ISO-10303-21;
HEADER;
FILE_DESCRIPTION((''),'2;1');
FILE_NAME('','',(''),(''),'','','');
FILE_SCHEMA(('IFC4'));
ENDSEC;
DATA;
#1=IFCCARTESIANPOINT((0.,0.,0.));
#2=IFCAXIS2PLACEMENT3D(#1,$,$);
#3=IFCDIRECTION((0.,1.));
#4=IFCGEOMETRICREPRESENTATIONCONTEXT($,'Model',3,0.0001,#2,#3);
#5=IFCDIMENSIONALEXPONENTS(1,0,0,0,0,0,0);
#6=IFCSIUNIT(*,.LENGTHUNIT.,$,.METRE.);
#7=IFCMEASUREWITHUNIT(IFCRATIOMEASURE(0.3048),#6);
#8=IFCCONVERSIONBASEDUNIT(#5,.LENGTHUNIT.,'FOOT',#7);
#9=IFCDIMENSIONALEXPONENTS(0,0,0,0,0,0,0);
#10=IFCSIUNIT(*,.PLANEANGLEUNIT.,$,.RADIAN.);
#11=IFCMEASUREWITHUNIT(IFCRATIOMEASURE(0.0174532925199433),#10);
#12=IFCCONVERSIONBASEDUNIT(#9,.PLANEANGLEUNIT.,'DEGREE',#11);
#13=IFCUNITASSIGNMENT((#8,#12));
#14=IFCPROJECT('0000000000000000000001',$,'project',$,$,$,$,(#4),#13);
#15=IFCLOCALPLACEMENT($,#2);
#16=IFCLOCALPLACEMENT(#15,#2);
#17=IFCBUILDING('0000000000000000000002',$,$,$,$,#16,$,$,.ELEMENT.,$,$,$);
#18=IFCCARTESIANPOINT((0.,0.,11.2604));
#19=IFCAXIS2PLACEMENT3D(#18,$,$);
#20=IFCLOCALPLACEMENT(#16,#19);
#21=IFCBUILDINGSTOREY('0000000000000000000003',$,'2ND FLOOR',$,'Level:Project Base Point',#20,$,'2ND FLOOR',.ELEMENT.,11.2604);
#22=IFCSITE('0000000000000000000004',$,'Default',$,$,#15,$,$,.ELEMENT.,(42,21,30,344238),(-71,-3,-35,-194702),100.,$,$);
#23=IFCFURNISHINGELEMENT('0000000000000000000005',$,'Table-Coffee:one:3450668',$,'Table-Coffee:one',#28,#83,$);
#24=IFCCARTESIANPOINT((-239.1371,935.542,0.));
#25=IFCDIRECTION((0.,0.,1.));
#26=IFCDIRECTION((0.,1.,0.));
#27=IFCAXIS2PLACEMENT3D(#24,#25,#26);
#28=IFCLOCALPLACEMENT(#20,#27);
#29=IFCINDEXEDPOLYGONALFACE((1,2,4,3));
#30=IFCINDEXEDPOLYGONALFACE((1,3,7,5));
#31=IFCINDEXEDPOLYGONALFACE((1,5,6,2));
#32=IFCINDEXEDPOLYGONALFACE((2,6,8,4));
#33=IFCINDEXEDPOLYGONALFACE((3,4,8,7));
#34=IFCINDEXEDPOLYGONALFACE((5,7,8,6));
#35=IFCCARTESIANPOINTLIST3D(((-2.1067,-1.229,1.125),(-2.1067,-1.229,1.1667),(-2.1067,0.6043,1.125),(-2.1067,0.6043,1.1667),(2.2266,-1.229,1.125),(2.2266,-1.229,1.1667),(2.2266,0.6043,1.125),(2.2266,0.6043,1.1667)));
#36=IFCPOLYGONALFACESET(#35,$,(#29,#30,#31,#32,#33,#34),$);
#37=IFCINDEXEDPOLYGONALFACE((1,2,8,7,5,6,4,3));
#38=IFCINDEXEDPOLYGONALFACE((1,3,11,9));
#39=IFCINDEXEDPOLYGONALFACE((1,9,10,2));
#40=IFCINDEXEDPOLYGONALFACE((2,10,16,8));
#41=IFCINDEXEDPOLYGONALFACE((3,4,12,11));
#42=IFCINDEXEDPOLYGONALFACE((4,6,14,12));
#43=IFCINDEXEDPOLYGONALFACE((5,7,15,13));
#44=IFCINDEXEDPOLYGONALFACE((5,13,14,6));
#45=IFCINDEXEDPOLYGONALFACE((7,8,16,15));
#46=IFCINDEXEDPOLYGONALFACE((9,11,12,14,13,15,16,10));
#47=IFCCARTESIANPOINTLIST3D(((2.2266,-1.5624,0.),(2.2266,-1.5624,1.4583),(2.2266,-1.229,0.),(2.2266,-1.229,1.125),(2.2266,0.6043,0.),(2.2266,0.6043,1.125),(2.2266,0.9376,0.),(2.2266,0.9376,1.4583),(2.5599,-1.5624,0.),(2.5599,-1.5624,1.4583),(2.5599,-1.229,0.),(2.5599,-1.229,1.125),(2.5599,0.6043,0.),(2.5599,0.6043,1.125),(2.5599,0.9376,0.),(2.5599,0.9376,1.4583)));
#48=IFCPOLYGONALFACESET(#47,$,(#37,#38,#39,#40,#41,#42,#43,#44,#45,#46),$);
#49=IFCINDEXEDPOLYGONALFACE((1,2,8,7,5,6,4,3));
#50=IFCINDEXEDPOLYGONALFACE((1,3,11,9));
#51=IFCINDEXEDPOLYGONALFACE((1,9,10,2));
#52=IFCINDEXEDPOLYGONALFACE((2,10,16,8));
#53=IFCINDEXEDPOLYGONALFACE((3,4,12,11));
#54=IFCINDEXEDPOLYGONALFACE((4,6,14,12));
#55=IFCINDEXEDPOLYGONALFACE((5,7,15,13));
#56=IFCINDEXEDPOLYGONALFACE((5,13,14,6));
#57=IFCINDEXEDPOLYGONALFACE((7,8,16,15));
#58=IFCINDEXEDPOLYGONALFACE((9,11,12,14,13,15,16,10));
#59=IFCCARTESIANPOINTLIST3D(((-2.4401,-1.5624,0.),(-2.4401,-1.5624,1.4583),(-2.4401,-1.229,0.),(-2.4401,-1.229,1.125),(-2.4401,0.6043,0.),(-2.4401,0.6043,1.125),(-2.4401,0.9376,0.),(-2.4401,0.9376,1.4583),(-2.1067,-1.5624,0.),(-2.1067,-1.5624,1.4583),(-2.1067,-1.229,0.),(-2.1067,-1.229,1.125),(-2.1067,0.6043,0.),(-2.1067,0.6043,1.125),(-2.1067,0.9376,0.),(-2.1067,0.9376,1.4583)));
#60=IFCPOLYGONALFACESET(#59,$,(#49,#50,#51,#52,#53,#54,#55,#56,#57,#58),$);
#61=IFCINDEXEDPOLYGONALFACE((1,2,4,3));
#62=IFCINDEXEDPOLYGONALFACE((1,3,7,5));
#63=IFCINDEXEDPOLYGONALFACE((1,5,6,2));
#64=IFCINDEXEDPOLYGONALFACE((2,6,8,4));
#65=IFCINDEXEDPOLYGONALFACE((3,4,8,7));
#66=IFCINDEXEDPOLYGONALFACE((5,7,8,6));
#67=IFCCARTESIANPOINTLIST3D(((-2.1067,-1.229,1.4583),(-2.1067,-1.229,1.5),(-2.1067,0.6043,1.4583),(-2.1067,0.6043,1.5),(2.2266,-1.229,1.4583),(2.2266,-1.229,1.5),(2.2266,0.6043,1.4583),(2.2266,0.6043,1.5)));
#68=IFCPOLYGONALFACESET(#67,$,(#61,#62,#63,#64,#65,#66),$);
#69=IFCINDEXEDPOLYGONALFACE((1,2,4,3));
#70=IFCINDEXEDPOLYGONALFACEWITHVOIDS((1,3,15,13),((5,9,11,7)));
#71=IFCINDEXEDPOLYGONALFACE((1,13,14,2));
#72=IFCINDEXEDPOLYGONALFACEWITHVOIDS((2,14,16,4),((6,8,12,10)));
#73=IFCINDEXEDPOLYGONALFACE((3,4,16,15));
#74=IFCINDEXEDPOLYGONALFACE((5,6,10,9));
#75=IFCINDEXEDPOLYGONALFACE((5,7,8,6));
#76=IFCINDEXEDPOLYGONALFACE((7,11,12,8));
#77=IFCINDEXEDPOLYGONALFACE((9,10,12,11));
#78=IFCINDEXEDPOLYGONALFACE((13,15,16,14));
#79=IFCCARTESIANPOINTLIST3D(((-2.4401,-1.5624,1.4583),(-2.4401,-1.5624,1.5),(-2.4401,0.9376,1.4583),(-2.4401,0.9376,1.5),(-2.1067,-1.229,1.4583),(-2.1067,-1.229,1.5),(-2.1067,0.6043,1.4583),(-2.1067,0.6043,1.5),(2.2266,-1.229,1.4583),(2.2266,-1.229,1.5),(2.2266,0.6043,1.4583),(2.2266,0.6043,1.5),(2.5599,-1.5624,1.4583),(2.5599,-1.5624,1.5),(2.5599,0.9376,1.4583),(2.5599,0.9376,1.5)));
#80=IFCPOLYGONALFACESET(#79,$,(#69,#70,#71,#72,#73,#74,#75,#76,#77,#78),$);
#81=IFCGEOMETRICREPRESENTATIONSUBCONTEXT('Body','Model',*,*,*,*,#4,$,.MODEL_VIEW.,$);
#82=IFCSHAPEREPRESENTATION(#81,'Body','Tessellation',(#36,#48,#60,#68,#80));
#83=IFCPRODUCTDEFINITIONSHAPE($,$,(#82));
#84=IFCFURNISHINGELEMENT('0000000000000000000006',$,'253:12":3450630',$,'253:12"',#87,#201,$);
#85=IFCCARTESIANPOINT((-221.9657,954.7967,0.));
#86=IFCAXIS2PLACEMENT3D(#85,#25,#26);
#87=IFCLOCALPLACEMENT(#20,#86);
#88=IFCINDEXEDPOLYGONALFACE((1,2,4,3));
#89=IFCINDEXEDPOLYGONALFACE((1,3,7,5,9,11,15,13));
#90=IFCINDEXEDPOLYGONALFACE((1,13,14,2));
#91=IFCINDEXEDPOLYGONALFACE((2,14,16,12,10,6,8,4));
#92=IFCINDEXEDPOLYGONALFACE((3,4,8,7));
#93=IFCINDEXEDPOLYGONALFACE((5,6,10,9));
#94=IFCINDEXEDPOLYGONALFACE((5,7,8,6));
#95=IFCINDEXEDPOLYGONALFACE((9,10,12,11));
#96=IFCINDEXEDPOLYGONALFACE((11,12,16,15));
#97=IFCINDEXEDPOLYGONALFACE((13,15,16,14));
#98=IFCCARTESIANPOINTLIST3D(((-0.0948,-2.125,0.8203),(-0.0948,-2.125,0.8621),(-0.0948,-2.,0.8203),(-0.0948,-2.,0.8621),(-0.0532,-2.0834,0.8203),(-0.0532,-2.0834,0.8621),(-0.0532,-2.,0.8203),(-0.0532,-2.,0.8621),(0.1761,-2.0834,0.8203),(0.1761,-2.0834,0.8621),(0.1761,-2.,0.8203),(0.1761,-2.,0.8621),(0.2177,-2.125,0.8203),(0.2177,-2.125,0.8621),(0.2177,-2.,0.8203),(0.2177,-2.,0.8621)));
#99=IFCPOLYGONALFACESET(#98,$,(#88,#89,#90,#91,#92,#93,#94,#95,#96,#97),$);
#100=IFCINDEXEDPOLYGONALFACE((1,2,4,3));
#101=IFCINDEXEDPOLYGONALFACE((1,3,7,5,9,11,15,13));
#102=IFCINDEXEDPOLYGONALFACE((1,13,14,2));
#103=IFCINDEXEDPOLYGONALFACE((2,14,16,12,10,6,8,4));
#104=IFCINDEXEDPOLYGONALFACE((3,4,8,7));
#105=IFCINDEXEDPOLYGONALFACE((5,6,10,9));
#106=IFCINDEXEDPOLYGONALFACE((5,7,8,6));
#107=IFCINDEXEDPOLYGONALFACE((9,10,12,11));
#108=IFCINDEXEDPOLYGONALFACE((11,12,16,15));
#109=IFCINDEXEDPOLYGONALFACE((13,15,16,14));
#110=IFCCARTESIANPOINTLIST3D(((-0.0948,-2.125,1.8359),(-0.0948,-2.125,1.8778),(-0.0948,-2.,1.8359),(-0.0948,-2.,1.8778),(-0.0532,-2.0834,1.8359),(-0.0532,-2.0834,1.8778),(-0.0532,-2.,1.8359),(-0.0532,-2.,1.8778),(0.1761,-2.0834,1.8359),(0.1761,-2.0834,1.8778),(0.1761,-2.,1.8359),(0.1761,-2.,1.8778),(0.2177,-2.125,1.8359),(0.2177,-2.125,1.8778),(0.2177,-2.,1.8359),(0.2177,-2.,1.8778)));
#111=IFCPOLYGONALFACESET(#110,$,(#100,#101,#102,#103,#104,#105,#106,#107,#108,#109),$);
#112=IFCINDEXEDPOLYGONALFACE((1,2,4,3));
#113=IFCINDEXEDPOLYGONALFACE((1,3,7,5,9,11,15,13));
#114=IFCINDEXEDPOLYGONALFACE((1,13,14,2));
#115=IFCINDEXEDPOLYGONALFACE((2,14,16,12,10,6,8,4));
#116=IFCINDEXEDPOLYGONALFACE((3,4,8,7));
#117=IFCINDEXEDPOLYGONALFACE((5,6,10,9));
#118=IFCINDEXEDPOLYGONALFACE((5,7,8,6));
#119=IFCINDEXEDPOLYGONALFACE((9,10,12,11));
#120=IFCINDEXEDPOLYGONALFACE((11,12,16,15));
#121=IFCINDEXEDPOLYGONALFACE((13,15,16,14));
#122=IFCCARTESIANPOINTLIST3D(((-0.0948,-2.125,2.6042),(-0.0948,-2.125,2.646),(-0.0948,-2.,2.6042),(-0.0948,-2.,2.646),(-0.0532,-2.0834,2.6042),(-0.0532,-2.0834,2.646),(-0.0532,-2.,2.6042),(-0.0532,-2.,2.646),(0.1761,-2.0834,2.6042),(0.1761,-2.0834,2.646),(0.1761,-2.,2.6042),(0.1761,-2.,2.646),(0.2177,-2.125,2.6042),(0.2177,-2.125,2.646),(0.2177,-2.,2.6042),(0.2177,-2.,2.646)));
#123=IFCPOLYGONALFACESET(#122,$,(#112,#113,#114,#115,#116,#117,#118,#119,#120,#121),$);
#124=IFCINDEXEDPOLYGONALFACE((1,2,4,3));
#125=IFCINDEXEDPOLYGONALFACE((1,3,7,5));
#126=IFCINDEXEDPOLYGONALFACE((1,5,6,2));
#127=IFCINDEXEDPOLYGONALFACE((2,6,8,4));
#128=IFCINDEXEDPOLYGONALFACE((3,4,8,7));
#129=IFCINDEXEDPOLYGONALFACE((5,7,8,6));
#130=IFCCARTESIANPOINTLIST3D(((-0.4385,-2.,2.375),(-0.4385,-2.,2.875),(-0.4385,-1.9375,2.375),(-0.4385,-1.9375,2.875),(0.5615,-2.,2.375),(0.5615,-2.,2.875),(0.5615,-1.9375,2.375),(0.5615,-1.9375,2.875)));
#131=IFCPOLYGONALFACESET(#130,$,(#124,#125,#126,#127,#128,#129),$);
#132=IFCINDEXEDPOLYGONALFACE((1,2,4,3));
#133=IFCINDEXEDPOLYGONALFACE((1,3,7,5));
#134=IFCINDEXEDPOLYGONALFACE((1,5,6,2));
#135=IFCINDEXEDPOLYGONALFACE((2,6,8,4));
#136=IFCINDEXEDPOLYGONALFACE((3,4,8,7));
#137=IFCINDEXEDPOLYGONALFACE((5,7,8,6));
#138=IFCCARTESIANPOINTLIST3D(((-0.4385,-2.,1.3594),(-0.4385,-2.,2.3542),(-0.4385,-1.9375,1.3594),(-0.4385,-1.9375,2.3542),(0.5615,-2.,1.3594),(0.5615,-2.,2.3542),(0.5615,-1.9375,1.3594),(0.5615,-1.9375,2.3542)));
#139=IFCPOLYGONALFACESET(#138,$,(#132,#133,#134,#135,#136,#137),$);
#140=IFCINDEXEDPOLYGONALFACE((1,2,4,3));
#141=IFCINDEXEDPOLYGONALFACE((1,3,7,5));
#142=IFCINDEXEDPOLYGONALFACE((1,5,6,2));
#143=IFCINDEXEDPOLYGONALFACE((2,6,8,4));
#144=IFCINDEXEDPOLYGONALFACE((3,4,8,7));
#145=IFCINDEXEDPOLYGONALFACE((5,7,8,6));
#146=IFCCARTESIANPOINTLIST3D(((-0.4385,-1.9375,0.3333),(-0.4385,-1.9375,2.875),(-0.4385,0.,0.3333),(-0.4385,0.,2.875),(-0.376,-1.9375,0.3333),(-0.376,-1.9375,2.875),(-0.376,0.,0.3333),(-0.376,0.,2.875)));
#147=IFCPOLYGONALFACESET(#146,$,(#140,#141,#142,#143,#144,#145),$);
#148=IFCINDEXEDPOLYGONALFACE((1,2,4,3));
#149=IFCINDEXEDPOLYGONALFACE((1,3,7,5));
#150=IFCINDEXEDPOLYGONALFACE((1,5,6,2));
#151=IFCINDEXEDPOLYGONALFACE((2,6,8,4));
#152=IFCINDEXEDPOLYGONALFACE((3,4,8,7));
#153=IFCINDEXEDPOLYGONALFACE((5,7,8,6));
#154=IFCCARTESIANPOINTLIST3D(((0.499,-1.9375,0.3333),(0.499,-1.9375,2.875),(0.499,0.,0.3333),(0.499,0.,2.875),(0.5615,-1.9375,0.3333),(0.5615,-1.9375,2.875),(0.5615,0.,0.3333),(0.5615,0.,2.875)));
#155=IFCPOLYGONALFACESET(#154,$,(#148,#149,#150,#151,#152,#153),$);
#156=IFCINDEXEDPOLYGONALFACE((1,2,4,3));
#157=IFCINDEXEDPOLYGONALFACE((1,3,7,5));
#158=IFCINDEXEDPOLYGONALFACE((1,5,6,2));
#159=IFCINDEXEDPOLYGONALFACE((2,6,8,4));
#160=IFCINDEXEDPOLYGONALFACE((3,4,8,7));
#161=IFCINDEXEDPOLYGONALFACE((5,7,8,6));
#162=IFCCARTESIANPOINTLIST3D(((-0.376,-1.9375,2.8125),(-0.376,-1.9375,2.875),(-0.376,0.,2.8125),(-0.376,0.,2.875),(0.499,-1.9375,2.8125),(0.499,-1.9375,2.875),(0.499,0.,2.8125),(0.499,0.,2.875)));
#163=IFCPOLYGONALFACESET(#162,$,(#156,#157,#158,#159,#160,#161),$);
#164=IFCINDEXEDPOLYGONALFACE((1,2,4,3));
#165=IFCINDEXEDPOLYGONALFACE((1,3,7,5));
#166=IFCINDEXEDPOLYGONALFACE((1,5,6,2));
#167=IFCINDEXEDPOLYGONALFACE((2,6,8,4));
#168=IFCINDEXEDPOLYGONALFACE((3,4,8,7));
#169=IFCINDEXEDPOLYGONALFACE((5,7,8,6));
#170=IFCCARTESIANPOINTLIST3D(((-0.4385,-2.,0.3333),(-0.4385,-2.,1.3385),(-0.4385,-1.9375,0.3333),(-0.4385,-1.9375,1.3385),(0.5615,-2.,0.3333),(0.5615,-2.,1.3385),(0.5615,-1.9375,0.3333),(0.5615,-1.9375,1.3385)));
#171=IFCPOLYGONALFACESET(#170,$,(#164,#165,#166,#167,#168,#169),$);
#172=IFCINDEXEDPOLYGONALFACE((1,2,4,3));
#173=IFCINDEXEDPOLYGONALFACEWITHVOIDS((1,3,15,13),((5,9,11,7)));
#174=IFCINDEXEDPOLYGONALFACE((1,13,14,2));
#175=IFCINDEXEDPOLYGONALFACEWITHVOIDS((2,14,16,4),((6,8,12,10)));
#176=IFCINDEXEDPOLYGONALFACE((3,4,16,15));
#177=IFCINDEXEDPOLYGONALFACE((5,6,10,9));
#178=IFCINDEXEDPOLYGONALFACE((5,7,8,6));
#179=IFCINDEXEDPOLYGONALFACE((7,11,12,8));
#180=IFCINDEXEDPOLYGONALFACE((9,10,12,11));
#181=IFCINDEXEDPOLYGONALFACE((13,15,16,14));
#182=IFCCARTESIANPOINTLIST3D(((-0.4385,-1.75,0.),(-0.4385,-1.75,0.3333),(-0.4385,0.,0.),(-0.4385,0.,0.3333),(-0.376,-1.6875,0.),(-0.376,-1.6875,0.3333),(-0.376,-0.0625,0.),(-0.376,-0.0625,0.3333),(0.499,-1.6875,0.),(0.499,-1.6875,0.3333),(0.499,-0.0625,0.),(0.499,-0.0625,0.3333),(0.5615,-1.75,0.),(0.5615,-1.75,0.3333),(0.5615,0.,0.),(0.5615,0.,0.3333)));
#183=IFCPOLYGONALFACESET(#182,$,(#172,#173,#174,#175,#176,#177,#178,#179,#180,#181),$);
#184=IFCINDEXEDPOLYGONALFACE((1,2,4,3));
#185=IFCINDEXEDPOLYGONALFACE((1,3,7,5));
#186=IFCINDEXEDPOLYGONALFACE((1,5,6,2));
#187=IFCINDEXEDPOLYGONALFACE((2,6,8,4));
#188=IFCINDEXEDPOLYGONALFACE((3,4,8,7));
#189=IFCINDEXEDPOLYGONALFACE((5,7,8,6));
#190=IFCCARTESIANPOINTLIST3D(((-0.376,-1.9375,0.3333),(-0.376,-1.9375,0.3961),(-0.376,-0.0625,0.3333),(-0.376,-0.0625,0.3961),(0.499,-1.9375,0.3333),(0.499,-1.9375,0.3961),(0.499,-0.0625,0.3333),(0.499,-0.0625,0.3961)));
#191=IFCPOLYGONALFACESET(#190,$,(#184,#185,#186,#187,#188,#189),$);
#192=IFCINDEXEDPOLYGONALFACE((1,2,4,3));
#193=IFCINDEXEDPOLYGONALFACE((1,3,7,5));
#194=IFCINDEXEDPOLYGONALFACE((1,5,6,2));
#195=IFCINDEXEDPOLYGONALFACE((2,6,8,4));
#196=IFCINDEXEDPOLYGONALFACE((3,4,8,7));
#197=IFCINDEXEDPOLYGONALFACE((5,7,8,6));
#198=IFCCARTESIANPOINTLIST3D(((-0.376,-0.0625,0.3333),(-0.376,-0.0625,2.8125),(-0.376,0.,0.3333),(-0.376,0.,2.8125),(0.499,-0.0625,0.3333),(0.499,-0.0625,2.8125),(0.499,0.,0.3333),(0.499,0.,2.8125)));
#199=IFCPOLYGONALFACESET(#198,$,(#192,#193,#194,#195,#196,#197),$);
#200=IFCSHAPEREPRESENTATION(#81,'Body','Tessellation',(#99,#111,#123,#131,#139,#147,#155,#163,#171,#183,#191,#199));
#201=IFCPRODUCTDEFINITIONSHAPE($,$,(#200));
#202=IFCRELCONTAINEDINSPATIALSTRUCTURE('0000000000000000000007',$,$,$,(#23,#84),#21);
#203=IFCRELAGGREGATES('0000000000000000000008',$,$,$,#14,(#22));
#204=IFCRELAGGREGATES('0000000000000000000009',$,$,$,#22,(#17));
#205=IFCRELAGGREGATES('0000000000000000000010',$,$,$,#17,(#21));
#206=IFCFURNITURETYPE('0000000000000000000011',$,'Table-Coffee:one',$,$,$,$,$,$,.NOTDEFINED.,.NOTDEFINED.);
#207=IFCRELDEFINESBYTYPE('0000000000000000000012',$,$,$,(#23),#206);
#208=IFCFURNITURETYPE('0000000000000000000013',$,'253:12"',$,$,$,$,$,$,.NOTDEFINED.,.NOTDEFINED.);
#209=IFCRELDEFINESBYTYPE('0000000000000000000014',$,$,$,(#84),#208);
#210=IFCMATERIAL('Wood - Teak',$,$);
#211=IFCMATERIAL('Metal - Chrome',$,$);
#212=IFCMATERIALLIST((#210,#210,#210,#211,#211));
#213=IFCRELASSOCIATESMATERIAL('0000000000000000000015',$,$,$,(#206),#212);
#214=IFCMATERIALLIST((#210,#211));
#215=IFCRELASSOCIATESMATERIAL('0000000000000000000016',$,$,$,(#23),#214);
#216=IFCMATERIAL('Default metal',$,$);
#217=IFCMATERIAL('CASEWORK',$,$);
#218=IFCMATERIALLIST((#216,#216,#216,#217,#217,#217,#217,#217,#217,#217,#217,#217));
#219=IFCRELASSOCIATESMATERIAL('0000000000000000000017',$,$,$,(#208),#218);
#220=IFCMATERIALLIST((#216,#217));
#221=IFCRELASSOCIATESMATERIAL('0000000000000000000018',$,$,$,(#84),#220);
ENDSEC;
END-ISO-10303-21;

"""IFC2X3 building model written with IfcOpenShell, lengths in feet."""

from ifc_helpers import new_model, entity, si_unit, converted_unit, direction, frame, frame_2d, origin, origin_2d_with_axis, place, context, subcontext, project, spatial, polyline, rectangle, outline, extrude, source, transform, mapped, material, material_list, type_object, type_shapes, element, save


model = new_model("IFC2X3")

# Units and contexts
model_context = context("Model", 3, precision=0.0001, world=origin(), true_north=direction((0.0, 1.0)))
body_context = subcontext(model_context, "Body", "Model", "MODEL_VIEW")
ifc_project = project(units=[converted_unit("LENGTHUNIT", "FOOT", entity("IfcRatioMeasure", 0.3048), si_unit("LENGTHUNIT", "METRE"), dimensions=[1, 0, 0, 0, 0, 0, 0]), converted_unit("PLANEANGLEUNIT", "DEGREE", entity("IfcRatioMeasure", 0.0174532925199433), si_unit("PLANEANGLEUNIT", "RADIAN"), dimensions=[0, 0, 0, 0, 0, 0, 0])], contexts=[model_context])

# Site, building, storey
site_placement = place(None, origin())
site = spatial("IfcSite", under=ifc_project, at=site_placement, Name="Default", CompositionType="ELEMENT", RefLatitude=(42, 21, 30, 344238), RefLongitude=(-71, -3, -35, -194702), RefElevation=100.0)
building_placement = place(site_placement, origin())
building = spatial("IfcBuilding", under=site, at=building_placement, CompositionType="ELEMENT")
storey_placement = place(building_placement, frame((0.0, 0.0, 11.2604)))
storey = spatial("IfcBuildingStorey", under=building, at=storey_placement, Name="2ND FLOOR", ObjectType="Level:Project Base Point", LongName="2ND FLOOR", CompositionType="ELEMENT", Elevation=11.2604)

# Furnishing elements
ifc_material_1 = material(Name="Metal - Chrome")
ifc_material_2 = material(Name="Default metal")
ifc_material_3 = material(Name="CASEWORK")
ifc_material_4 = material(Name="Wood - Teak")
ifc_material_list_1 = material_list([ifc_material_4, ifc_material_1])
ifc_material_list_2 = material_list([ifc_material_4, ifc_material_4, ifc_material_4, ifc_material_1, ifc_material_1])
furniture_type_1 = type_object("IfcFurnitureType", Name="Table-Coffee:one", material=ifc_material_list_2)
shared_shape_1 = source(origin(), body_context, "Body", "SweptSolid", [
    extrude(rectangle(XDim=1.8333, YDim=4.3333, at=origin_2d_with_axis()), frame((0.0599, -0.3124, 1.125), z_axis=(0.0, 0.0, 1.0), x_axis=(0.0, 1.0, 0.0)), (0.0, 0.0, 1.0), 0.0417),
    extrude(outline(polyline([(-1.25, -0.6458), (-0.9167, -0.6458), (-0.9167, 0.4792), (0.9167, 0.4792), (0.9167, -0.6458), (1.25, -0.6458), (1.25, 0.8125), (-1.25, 0.8125), (-1.25, -0.6458)])), frame((2.2266, -0.3124, 0.6458), z_axis=(1.0, 0.0, 0.0), x_axis=(0.0, 1.0, 0.0)), (0.0, 0.0, 1.0), 0.3333),
    extrude(outline(polyline([(-0.8125, -1.25), (0.6458, -1.25), (0.6458, -0.9167), (-0.4792, -0.9167), (-0.4792, 0.9167), (0.6458, 0.9167), (0.6458, 1.25), (-0.8125, 1.25), (-0.8125, -1.25)])), frame((-2.4401, -0.3124, 0.6458), z_axis=(1.0, 0.0, 0.0), x_axis=(0.0, 0.0, -1.0)), (0.0, 0.0, 1.0), 0.3333),
    extrude(rectangle(XDim=1.8333, YDim=4.3333, at=origin_2d_with_axis()), frame((0.0599, -0.3124, 1.4583), z_axis=(0.0, 0.0, 1.0), x_axis=(0.0, 1.0, 0.0)), (0.0, 0.0, 1.0), 0.0417),
    extrude(outline(polyline([(-1.25, -2.5), (1.25, -2.5), (1.25, 2.5), (-1.25, 2.5), (-1.25, -2.5)]), holes=[polyline([(-0.9167, -2.1667), (-0.9167, 2.1667), (0.9167, 2.1667), (0.9167, -2.1667), (-0.9167, -2.1667)])]), frame((0.0599, -0.3124, 1.4583), z_axis=(0.0, 0.0, 1.0), x_axis=(0.0, 1.0, 0.0)), (0.0, 0.0, 1.0), 0.0417),
])
type_shapes(furniture_type_1, [shared_shape_1])
furnishing_1_placement = place(storey_placement, frame((-239.1371, 935.542, 0.0), z_axis=(0.0, 0.0, 1.0), x_axis=(0.0, 1.0, 0.0)))
element("IfcFurnishingElement", 1, at=furnishing_1_placement, inside=storey, type_object=furniture_type_1, material=ifc_material_list_1, Name="Table-Coffee:one:3450668", ObjectType="Table-Coffee:one", context=body_context, shape_type="MappedRepresentation", body=[
    mapped(shared_shape_1, transform((0.0, 0.0, 0.0), scale=1.0)),
])
ifc_material_list_3 = material_list([ifc_material_2, ifc_material_3])
ifc_material_list_4 = material_list([ifc_material_2, ifc_material_2, ifc_material_2, ifc_material_3, ifc_material_3, ifc_material_3, ifc_material_3, ifc_material_3, ifc_material_3, ifc_material_3, ifc_material_3, ifc_material_3])
furniture_type_2 = type_object("IfcFurnitureType", Name="253:12\"", material=ifc_material_list_4)
shared_shape_2 = source(origin(), body_context, "Body", "SweptSolid", [
    extrude(outline(polyline([(-0.0521, -0.1562), (0.0729, -0.1562), (0.0729, 0.1562), (-0.0521, 0.1562), (-0.0521, 0.1146), (0.0313, 0.1146), (0.0313, -0.1146), (-0.0521, -0.1146), (-0.0521, -0.1562)])), frame((0.0615, -2.0521, 0.8203), z_axis=(0.0, 0.0, 1.0), x_axis=(0.0, -1.0, 0.0)), (0.0, 0.0, 1.0), 0.0418),
    extrude(outline(polyline([(-0.0521, -0.1562), (0.0729, -0.1562), (0.0729, 0.1562), (-0.0521, 0.1562), (-0.0521, 0.1146), (0.0313, 0.1146), (0.0313, -0.1146), (-0.0521, -0.1146), (-0.0521, -0.1562)])), frame((0.0615, -2.0521, 1.8359), z_axis=(0.0, 0.0, 1.0), x_axis=(0.0, -1.0, 0.0)), (0.0, 0.0, 1.0), 0.0418),
    extrude(outline(polyline([(-0.0521, -0.1562), (0.0729, -0.1562), (0.0729, 0.1562), (-0.0521, 0.1562), (-0.0521, 0.1146), (0.0313, 0.1146), (0.0313, -0.1146), (-0.0521, -0.1146), (-0.0521, -0.1562)])), frame((0.0615, -2.0521, 2.6042), z_axis=(0.0, 0.0, 1.0), x_axis=(0.0, -1.0, 0.0)), (0.0, 0.0, 1.0), 0.0418),
    extrude(rectangle(XDim=0.0625, YDim=1.0, at=origin_2d_with_axis()), frame((0.0615, -1.9688, 2.375), z_axis=(0.0, 0.0, 1.0), x_axis=(0.0, 1.0, 0.0)), (0.0, 0.0, 1.0), 0.5),
    extrude(rectangle(XDim=0.0625, YDim=1.0, at=origin_2d_with_axis()), frame((0.0615, -1.9688, 1.3594), z_axis=(0.0, 0.0, 1.0), x_axis=(0.0, 1.0, 0.0)), (0.0, 0.0, 1.0), 0.9948),
    extrude(rectangle(XDim=0.0625, YDim=1.9375, at=frame_2d((0.0, 0.0), x_axis=(1.0, 0.0))), frame((-0.4073, -0.9687, 0.3333)), (0.0, 0.0, 1.0), 2.5417),
    extrude(rectangle(XDim=0.0625, YDim=1.9375, at=frame_2d((0.0, 0.0), x_axis=(1.0, 0.0))), frame((0.5302, -0.9687, 0.3333)), (0.0, 0.0, 1.0), 2.5417),
    extrude(rectangle(XDim=0.875, YDim=1.9375, at=origin_2d_with_axis()), frame((0.0615, -0.9688, 2.8125), z_axis=(0.0, 0.0, 1.0), x_axis=(-1.0, 0.0, 0.0)), (0.0, 0.0, 1.0), 0.0625),
    extrude(rectangle(XDim=0.0625, YDim=1.0, at=origin_2d_with_axis()), frame((0.0615, -1.9688, 0.3333), z_axis=(0.0, 0.0, 1.0), x_axis=(0.0, 1.0, 0.0)), (0.0, 0.0, 1.0), 1.0052),
    extrude(outline(polyline([(-0.5, -0.875), (0.5, -0.875), (0.5, 0.875), (-0.5, 0.875), (-0.5, -0.875)]), holes=[polyline([(-0.4375, -0.8125), (-0.4375, 0.8125), (0.4375, 0.8125), (0.4375, -0.8125), (-0.4375, -0.8125)])]), frame((0.0615, -0.875, 0.0)), (0.0, 0.0, 1.0), 0.3333),
    extrude(rectangle(XDim=0.875, YDim=1.875, at=frame_2d((0.0, 0.0), x_axis=(1.0, 0.0))), frame((0.0615, -1.0, 0.3333), z_axis=(0.0, 0.0, 1.0), x_axis=(-1.0, 0.0, 0.0)), (0.0, 0.0, 1.0), 0.0627),
    extrude(rectangle(XDim=0.0625, YDim=0.875, at=origin_2d_with_axis()), frame((0.0615, -0.0312, 0.3333), z_axis=(0.0, 0.0, 1.0), x_axis=(0.0, 1.0, 0.0)), (0.0, 0.0, 1.0), 2.4792),
])
type_shapes(furniture_type_2, [shared_shape_2])
furnishing_2_placement = place(storey_placement, frame((-221.9657, 954.7967, 0.0), z_axis=(0.0, 0.0, 1.0), x_axis=(0.0, 1.0, 0.0)))
element("IfcFurnishingElement", 2, at=furnishing_2_placement, inside=storey, type_object=furniture_type_2, material=ifc_material_list_3, Name="253:12\":3450630", ObjectType="253:12\"", context=body_context, shape_type="MappedRepresentation", body=[
    mapped(shared_shape_2, transform((0.0, 0.0, 0.0), scale=1.0)),
])

save(model, "model.ifc")
